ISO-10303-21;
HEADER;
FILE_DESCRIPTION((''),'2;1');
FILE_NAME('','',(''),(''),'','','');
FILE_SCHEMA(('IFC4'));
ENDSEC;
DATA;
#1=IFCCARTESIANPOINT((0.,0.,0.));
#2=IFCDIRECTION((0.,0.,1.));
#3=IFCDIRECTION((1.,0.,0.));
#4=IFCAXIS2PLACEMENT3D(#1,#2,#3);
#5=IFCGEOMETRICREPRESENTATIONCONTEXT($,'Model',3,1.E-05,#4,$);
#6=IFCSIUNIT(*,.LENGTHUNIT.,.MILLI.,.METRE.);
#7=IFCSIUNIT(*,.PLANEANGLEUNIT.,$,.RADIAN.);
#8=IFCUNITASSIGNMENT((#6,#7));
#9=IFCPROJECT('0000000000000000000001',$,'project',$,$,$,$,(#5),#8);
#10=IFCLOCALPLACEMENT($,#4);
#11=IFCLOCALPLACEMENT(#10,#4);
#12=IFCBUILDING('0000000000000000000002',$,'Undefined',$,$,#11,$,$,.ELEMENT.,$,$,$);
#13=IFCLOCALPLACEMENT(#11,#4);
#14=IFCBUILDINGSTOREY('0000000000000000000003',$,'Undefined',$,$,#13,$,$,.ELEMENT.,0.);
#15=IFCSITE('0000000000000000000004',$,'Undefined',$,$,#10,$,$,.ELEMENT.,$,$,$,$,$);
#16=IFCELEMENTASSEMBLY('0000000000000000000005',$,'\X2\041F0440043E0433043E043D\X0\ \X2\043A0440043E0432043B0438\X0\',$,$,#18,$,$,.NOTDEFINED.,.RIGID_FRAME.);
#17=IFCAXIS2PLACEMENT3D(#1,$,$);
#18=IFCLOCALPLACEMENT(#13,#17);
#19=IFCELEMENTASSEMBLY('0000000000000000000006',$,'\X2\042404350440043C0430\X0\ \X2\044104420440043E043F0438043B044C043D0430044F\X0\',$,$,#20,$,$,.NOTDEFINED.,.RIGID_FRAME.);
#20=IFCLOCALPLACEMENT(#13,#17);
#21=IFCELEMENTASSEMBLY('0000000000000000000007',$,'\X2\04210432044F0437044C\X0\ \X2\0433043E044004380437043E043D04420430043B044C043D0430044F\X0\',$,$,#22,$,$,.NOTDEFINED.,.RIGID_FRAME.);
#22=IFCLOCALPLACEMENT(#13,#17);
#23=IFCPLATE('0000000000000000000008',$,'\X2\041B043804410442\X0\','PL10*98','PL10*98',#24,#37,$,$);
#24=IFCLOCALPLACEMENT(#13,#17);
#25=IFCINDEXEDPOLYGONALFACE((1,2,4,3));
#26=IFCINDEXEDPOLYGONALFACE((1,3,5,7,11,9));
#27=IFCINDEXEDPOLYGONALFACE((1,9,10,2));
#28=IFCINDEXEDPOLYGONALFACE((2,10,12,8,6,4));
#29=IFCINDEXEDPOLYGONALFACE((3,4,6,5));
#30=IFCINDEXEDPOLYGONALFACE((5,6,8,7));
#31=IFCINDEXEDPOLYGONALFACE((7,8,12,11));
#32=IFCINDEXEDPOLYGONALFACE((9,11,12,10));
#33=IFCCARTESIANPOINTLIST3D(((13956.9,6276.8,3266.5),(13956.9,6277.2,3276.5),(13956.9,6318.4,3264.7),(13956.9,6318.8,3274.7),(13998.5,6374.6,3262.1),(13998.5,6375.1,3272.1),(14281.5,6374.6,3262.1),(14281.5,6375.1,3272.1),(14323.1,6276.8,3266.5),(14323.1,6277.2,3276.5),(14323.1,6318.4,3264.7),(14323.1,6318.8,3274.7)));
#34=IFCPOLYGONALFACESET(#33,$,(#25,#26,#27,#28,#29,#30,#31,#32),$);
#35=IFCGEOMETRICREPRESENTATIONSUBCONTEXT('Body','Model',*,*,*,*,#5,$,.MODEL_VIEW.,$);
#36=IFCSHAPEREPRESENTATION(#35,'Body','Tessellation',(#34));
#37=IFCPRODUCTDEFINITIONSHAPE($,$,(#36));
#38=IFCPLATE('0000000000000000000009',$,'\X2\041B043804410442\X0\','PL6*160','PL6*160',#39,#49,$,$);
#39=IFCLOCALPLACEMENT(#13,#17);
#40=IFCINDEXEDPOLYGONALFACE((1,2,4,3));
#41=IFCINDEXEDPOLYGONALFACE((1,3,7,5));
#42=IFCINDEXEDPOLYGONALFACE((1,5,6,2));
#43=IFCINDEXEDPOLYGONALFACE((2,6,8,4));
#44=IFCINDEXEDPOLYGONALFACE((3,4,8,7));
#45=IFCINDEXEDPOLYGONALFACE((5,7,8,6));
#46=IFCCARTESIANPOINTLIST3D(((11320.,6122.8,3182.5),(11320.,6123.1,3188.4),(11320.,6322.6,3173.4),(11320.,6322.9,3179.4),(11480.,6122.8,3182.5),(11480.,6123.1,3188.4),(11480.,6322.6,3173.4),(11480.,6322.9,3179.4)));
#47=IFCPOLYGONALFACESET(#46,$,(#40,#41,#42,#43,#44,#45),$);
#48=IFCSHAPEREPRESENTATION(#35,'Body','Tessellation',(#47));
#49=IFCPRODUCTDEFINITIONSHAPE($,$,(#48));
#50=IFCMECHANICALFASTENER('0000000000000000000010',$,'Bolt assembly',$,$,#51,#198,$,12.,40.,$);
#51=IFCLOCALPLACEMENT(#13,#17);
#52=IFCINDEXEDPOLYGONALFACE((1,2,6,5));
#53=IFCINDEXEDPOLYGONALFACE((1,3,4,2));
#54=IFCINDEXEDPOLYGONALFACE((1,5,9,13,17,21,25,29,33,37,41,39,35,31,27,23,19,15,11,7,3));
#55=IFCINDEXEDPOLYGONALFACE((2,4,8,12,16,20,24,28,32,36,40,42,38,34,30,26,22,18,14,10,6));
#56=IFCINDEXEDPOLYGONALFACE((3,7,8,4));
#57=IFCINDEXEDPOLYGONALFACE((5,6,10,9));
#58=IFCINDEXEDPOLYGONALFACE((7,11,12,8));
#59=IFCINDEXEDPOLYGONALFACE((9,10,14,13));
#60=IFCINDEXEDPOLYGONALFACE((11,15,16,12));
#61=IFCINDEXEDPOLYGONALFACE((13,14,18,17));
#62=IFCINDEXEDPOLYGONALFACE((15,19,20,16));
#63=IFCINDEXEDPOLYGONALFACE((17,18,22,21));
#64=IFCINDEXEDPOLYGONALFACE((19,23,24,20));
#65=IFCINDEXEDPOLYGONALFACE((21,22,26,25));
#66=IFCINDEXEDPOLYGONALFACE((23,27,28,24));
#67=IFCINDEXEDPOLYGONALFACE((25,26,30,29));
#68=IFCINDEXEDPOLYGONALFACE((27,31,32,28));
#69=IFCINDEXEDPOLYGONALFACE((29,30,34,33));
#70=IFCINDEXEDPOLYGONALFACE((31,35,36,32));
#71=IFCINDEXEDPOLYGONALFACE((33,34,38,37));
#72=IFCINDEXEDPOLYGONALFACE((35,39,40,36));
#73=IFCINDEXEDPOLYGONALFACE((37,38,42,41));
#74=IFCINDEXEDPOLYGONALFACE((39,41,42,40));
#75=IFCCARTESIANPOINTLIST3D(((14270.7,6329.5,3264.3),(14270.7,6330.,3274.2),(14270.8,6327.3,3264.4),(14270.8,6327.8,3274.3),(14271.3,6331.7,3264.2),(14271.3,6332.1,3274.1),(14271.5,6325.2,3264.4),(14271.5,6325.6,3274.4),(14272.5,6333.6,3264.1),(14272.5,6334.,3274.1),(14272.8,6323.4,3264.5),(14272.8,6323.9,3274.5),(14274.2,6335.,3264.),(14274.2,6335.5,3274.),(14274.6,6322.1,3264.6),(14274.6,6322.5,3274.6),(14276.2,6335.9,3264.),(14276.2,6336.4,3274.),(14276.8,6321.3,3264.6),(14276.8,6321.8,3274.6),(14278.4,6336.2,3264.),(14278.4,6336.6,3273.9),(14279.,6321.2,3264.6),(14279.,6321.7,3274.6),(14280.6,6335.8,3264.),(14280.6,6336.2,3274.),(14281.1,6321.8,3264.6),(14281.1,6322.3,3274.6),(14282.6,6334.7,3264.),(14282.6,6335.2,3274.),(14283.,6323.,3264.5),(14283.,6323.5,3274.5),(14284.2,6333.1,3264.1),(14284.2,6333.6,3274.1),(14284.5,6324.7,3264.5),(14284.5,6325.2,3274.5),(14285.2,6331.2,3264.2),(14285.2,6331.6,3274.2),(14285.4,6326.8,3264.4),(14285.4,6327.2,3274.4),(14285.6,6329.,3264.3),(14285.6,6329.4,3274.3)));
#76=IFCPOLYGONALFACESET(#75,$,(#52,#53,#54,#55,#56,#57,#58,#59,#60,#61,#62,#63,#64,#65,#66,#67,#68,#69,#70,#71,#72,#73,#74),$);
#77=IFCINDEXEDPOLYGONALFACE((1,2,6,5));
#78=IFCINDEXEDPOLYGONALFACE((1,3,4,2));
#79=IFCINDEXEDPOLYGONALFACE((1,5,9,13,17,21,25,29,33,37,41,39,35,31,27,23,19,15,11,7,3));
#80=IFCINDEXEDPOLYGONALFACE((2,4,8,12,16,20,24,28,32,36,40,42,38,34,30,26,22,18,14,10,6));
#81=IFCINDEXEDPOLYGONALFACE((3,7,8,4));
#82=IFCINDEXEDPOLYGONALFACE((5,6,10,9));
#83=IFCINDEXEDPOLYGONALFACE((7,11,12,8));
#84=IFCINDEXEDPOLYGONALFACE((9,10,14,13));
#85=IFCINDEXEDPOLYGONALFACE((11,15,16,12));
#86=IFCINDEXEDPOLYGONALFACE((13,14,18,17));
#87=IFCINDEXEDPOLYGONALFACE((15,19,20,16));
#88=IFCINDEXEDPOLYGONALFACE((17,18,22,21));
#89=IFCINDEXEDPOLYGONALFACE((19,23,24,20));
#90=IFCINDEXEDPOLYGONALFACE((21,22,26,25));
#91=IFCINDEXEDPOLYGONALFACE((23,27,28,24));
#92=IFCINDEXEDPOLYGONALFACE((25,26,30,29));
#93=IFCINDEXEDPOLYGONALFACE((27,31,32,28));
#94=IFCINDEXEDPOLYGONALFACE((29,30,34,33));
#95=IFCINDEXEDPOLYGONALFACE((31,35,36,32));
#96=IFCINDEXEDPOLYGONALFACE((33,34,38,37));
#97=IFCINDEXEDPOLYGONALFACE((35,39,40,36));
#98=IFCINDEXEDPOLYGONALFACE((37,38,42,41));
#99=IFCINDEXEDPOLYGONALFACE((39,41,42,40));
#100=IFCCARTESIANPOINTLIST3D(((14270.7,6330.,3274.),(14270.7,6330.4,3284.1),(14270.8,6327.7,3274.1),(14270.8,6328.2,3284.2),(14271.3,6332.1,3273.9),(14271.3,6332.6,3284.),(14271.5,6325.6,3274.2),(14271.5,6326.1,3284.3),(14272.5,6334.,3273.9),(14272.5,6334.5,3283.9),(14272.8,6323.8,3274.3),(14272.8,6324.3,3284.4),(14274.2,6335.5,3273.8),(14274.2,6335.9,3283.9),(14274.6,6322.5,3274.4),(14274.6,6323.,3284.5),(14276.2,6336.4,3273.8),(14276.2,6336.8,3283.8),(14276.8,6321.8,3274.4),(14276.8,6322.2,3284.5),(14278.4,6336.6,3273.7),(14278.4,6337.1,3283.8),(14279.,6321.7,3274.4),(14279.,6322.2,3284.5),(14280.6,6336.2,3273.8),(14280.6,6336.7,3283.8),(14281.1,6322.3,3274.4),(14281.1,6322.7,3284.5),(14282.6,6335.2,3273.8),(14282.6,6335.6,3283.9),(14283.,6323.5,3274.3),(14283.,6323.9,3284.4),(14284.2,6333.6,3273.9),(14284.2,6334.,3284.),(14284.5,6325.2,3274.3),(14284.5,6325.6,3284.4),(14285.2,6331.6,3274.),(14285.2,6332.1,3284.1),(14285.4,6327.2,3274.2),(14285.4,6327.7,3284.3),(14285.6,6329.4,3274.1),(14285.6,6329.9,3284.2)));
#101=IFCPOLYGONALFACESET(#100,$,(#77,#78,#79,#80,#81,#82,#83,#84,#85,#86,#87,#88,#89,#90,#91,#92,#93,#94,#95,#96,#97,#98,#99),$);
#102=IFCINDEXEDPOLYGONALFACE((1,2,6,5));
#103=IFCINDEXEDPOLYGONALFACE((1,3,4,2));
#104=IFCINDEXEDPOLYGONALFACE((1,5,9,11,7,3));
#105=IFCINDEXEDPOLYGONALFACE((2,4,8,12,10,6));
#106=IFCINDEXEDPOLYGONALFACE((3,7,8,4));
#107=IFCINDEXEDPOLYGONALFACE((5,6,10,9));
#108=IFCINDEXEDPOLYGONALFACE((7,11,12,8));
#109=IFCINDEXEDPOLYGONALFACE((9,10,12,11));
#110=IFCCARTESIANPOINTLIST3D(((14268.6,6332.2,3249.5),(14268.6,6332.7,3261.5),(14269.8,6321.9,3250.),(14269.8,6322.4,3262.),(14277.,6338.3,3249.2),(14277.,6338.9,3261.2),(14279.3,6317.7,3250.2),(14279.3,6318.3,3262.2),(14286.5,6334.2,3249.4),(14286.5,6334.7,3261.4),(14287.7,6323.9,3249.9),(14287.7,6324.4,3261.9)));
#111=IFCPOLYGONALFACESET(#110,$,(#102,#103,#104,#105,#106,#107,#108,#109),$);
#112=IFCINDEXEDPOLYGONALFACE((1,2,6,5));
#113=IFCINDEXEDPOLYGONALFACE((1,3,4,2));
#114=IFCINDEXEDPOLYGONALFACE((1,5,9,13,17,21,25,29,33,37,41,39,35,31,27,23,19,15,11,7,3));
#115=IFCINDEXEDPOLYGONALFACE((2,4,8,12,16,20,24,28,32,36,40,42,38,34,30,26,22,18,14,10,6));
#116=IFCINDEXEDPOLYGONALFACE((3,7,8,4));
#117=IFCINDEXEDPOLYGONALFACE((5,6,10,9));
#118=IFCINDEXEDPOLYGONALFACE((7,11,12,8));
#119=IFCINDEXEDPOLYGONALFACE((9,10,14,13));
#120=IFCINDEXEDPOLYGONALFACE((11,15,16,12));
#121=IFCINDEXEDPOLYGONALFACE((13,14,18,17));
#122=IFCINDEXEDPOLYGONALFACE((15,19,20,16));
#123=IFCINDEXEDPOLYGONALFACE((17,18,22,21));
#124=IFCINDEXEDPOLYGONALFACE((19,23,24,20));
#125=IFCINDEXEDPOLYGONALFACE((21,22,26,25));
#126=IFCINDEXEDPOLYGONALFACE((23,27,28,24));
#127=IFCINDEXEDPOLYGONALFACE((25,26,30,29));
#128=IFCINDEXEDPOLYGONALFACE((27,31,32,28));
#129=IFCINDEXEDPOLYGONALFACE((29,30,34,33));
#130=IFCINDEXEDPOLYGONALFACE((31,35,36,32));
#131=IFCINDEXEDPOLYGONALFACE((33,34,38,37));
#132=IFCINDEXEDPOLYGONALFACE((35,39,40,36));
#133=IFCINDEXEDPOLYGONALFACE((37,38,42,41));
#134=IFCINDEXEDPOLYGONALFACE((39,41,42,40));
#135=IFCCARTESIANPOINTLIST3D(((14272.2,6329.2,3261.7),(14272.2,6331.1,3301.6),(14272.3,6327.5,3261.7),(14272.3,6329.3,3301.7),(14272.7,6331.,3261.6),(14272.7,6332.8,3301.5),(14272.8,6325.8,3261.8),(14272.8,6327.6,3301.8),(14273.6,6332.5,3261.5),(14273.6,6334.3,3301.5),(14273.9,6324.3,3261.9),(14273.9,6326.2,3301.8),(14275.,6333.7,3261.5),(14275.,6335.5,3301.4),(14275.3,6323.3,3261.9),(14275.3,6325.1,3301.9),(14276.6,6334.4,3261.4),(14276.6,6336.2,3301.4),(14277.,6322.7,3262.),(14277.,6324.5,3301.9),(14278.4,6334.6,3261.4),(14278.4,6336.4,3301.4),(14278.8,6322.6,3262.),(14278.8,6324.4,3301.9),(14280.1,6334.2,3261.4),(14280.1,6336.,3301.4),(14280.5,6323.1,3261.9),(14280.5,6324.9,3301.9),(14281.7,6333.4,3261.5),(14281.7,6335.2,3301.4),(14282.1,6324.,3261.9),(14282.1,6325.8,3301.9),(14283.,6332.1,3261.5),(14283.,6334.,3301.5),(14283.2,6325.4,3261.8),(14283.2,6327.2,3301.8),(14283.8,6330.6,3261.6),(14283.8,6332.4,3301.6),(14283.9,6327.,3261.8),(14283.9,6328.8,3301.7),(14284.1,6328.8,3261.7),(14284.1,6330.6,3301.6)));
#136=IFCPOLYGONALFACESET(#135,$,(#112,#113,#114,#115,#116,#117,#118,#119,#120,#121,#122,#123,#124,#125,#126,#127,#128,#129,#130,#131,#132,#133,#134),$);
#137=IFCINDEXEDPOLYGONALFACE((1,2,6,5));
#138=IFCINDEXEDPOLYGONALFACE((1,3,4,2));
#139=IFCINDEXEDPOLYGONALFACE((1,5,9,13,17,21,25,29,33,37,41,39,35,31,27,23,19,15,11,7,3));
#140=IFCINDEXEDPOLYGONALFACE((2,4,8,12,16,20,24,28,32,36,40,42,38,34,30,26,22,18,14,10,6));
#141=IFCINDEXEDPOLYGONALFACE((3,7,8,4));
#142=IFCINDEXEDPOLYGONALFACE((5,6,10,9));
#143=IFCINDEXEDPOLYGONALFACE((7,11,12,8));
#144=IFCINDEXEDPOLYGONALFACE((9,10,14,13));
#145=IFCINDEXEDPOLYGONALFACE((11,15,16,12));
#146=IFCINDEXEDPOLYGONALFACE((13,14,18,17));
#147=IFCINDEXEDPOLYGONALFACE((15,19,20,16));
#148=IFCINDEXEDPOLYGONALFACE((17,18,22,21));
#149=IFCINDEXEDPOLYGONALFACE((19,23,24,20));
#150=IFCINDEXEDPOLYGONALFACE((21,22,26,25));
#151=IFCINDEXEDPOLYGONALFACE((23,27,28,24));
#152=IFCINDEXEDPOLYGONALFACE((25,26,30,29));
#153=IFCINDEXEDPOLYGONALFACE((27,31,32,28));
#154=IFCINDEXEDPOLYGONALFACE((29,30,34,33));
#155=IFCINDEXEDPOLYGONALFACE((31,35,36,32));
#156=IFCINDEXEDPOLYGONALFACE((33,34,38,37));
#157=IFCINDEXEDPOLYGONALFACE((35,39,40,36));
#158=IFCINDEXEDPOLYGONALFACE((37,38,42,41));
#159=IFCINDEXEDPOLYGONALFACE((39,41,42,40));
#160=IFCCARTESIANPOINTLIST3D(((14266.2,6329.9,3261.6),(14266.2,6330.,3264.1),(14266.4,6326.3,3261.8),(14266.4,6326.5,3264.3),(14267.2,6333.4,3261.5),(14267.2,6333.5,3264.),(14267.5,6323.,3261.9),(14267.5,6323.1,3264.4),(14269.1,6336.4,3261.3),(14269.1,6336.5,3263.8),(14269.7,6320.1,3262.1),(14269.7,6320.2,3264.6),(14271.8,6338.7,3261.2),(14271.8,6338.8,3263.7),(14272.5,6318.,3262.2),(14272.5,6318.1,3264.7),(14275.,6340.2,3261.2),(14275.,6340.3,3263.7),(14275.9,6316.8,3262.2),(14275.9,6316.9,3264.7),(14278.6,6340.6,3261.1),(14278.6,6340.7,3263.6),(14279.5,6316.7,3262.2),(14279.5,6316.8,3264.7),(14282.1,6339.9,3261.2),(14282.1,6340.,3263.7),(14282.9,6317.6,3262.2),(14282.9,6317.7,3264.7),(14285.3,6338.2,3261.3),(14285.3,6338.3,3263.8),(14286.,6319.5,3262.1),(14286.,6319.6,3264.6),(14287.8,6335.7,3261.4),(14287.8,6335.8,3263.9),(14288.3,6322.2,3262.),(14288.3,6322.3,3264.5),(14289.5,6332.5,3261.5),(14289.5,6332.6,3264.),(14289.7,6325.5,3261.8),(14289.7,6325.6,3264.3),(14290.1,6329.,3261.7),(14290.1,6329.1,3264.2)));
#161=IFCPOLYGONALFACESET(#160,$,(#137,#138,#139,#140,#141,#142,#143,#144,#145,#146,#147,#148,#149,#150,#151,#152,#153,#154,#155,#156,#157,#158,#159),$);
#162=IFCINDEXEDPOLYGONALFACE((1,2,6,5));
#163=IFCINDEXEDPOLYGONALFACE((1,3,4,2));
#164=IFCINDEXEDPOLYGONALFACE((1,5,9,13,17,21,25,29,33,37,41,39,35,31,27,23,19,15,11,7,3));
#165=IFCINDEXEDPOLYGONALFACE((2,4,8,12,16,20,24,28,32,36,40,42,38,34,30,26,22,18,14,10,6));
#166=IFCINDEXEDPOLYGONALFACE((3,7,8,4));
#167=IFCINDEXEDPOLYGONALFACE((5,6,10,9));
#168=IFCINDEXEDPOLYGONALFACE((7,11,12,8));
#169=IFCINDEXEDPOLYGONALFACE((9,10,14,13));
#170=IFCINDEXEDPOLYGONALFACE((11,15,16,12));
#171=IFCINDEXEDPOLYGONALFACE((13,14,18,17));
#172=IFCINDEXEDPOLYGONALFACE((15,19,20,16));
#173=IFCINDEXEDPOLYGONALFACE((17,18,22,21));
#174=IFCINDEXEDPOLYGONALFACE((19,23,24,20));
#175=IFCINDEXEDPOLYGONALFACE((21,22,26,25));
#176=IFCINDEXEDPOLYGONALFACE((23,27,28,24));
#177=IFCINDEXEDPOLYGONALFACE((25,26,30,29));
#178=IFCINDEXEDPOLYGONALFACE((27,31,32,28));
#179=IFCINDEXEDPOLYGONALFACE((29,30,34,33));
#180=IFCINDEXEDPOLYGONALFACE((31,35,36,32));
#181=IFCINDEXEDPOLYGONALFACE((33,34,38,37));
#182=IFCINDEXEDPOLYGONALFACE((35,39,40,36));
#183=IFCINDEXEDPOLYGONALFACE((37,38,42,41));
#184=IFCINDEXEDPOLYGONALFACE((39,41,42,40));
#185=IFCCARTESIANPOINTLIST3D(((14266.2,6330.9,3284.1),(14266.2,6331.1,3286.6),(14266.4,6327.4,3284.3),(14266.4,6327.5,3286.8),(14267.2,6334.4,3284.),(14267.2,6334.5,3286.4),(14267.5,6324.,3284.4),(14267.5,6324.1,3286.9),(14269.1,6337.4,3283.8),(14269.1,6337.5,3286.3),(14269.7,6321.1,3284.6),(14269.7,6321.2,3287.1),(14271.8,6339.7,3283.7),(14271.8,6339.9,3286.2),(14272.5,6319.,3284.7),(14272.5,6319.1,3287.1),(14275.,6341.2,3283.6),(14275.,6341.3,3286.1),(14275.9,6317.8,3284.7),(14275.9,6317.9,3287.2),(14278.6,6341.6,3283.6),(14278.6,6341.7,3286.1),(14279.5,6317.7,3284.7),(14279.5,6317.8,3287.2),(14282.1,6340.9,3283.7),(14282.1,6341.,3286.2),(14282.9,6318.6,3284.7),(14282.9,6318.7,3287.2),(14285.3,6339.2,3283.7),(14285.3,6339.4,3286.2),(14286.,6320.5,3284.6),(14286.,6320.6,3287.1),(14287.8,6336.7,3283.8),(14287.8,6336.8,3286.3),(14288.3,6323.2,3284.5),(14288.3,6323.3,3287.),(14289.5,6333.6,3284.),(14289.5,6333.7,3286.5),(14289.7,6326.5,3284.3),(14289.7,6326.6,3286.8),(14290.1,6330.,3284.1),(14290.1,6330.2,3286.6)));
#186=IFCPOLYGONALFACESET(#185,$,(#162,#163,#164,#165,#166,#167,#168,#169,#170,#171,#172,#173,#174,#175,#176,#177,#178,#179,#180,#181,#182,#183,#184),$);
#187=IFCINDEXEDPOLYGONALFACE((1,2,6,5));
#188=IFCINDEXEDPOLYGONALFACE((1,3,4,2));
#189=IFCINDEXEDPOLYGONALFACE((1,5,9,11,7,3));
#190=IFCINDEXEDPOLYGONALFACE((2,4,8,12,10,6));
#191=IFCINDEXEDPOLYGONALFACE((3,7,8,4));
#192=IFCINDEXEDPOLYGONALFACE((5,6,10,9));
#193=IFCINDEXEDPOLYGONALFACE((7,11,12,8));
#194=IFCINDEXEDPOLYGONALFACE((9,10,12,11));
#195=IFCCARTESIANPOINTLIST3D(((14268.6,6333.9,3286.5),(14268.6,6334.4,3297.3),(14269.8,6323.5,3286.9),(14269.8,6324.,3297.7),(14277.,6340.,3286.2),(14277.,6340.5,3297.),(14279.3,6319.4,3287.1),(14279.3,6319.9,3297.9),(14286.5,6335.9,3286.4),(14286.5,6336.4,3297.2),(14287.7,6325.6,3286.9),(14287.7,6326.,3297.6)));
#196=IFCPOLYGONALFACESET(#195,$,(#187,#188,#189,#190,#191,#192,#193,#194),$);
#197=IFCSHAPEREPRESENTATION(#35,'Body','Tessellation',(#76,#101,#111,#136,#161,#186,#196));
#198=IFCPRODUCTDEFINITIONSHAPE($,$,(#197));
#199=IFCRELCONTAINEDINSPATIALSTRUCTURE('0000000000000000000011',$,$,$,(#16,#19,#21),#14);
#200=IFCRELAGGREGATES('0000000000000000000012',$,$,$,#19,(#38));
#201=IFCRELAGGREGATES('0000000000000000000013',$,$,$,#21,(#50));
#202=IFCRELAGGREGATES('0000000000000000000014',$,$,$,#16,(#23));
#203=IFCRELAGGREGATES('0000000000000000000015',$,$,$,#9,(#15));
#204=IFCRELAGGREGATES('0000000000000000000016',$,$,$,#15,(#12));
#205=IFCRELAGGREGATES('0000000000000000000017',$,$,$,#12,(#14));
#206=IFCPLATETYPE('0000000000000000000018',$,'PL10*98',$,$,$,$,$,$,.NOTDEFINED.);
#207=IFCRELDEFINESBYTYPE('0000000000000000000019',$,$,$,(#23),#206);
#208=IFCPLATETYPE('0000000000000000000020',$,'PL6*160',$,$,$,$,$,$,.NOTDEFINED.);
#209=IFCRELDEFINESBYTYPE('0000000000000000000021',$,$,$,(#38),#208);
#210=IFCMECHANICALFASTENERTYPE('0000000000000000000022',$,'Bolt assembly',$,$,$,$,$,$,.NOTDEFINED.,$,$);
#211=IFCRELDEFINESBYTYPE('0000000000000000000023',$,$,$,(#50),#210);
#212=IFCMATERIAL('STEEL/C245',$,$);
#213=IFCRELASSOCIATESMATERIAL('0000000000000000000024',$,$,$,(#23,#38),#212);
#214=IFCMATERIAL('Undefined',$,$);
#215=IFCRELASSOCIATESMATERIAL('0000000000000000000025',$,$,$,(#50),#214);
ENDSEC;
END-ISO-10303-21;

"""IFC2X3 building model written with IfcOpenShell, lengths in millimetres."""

from ifc_helpers import new_model, si_unit, frame, origin_with_axes, origin_2d_with_axis, place, context, subcontext, project, spatial, polyline, circle, outline, extrude, source, transform, mapped, material, type_object, element, aggregate, save


model = new_model("IFC2X3")

# Units and contexts
model_context = context("Model", 3, precision=1e-05, world=origin_with_axes())
body_context = subcontext(model_context, "Body", "Model", "MODEL_VIEW")
ifc_project = project(units=[si_unit("LENGTHUNIT", "METRE", prefix="MILLI"), si_unit("PLANEANGLEUNIT", "RADIAN")], contexts=[model_context])

# Site, building, storey
site_placement = place(None, origin_with_axes())
site = spatial("IfcSite", under=ifc_project, at=site_placement, Name="Undefined", CompositionType="ELEMENT")
building_placement = place(site_placement, origin_with_axes())
building = spatial("IfcBuilding", under=site, at=building_placement, Name="Undefined", CompositionType="ELEMENT")
storey_placement = place(building_placement, origin_with_axes())
storey = spatial("IfcBuildingStorey", under=building, at=storey_placement, Name="Undefined", CompositionType="ELEMENT", Elevation=0.0)

# Shared definitions
ifc_material_1 = material(Name="STEEL/C245")

# Element assembly
assembly_1_placement = place(storey_placement, origin_with_axes())
assembly_1 = element("IfcElementAssembly", 1, at=assembly_1_placement, inside=storey, Name="Прогон кровли", AssemblyPlace="NOTDEFINED", PredefinedType="RIGID_FRAME")

# Element assembly
assembly_2_placement = place(storey_placement, origin_with_axes())
assembly_2 = element("IfcElementAssembly", 2, at=assembly_2_placement, inside=storey, Name="Ферма стропильная", AssemblyPlace="NOTDEFINED", PredefinedType="RIGID_FRAME")

# Element assembly
assembly_3_placement = place(storey_placement, origin_with_axes())
assembly_3 = element("IfcElementAssembly", 3, at=assembly_3_placement, inside=storey, Name="Связь горизонтальная", AssemblyPlace="NOTDEFINED", PredefinedType="RIGID_FRAME")

# Plates
plate_type_1 = type_object("IfcPlateType", Name="PL10*98", PredefinedType="NOTDEFINED")
plate_1_placement = place(assembly_1_placement, frame((13956.9, 6277.0, 3271.5), z_axis=(0.0, -0.045408, -0.998969), x_axis=(0.0, 0.998969, -0.045408)))
plate_1 = element("IfcPlate", 4, at=plate_1_placement, type_object=plate_type_1, material=ifc_material_1, Name="Лист", Description="PL10*98", ObjectType="PL10*98", context=body_context, shape_type="SweptSolid", body=[
    extrude(outline(polyline([(0.0, 0.0), (41.6, 0.0), (97.9, 41.6), (97.9, 324.6), (41.6, 366.1), (0.0, 366.1), (0.0, 0.0)])), frame((0.0, 0.0, -5.0), z_axis=(0.0, 0.0, 1.0), x_axis=(1.0, 0.0, 0.0)), (0.0, 0.0, 1.0), 10.0),
])
plate_type_2 = type_object("IfcPlateType", Name="PL6*160", PredefinedType="NOTDEFINED")
plate_2_placement = place(assembly_2_placement, frame((11480.0, 6122.9, 3185.5), z_axis=(0.0, -0.045408, -0.998969), x_axis=(-1.0, 0.0, 0.0)))
plate_2 = element("IfcPlate", 5, at=plate_2_placement, type_object=plate_type_2, material=ifc_material_1, Name="Лист", Description="PL6*160", ObjectType="PL6*160", context=body_context, shape_type="SweptSolid", body=[
    extrude(outline(polyline([(0.0, 0.0), (160.0, 0.0), (160.0, 200.0), (0.0, 200.0), (0.0, 0.0)])), frame((0.0, 0.0, -3.0), z_axis=(0.0, 0.0, 1.0), x_axis=(1.0, 0.0, 0.0)), (0.0, 0.0, 1.0), 6.0),
])
aggregate(assembly_2, [plate_2])

# Mechanical fastener
ifc_material_2 = material(Name="Undefined")
mechanical_fastener_type = type_object("IfcMechanicalFastenerType", Name="Bolt assembly")
shared_shape_1 = source(origin_with_axes(), body_context, "Body", "SweptSolid", [
    extrude(circle(Radius=7.5, at=origin_2d_with_axis()), frame((0.0, 0.1, 0.0), z_axis=(0.0, 1.0, 0.0), x_axis=(1.0, 0.0, 0.0)), (0.0, 0.0, 1.0), 10.0),
    extrude(circle(Radius=7.5, at=origin_2d_with_axis()), frame((0.0, 9.9, 0.0), z_axis=(0.0, 1.0, 0.0), x_axis=(1.0, 0.0, 0.0)), (0.0, 0.0, 1.0), 10.1),
    extrude(outline(polyline([(10.4, 0.0), (5.2, 9.0), (-5.2, 9.0), (-10.4, 0.0), (-5.2, -9.0), (5.2, -9.0), (10.4, 0.0)])), frame((0.0, -14.5, 0.0), z_axis=(0.0, 1.0, 0.0), x_axis=(1.0, 0.0, 0.0)), (0.0, 0.0, 1.0), 12.0),
    extrude(circle(Radius=6.0, at=origin_2d_with_axis()), frame((0.0, -2.5, 0.0), z_axis=(0.0, 1.0, 0.0), x_axis=(1.0, 0.0, 0.0)), (0.0, 0.0, 1.0), 40.0),
    extrude(circle(Radius=12.0, at=origin_2d_with_axis()), frame((0.0, -2.5, 0.0), z_axis=(0.0, 1.0, 0.0), x_axis=(1.0, 0.0, 0.0)), (0.0, 0.0, 1.0), 2.5),
    extrude(circle(Radius=12.0, at=origin_2d_with_axis()), frame((0.0, 20.0, 0.0), z_axis=(0.0, 1.0, 0.0), x_axis=(1.0, 0.0, 0.0)), (0.0, 0.0, 1.0), 2.5),
    extrude(outline(polyline([(10.4, 0.0), (5.2, 9.0), (-5.2, 9.0), (-10.4, 0.0), (-5.2, -9.0), (5.2, -9.0), (10.4, 0.0)])), frame((0.0, 22.5, 0.0), z_axis=(0.0, 1.0, 0.0), x_axis=(1.0, 0.0, 0.0)), (0.0, 0.0, 1.0), 10.8),
])
mechanical_fastener_1_placement = place(assembly_3_placement, frame((14278.1, 6328.7, 3264.2), z_axis=(0.593795, -0.803786, 0.036536), x_axis=(0.804616, 0.593183, -0.026963)))
mechanical_fastener_1 = element("IfcMechanicalFastener", 6, at=mechanical_fastener_1_placement, type_object=mechanical_fastener_type, material=ifc_material_2, Name="Bolt assembly", NominalDiameter=12.0, NominalLength=40.0, context=body_context, shape_type="MappedRepresentation", body=[
    mapped(shared_shape_1, transform((0.0, 0.0, 0.0))),
])
aggregate(assembly_3, [mechanical_fastener_1])
aggregate(assembly_1, [plate_1])

save(model, "model.ifc")
